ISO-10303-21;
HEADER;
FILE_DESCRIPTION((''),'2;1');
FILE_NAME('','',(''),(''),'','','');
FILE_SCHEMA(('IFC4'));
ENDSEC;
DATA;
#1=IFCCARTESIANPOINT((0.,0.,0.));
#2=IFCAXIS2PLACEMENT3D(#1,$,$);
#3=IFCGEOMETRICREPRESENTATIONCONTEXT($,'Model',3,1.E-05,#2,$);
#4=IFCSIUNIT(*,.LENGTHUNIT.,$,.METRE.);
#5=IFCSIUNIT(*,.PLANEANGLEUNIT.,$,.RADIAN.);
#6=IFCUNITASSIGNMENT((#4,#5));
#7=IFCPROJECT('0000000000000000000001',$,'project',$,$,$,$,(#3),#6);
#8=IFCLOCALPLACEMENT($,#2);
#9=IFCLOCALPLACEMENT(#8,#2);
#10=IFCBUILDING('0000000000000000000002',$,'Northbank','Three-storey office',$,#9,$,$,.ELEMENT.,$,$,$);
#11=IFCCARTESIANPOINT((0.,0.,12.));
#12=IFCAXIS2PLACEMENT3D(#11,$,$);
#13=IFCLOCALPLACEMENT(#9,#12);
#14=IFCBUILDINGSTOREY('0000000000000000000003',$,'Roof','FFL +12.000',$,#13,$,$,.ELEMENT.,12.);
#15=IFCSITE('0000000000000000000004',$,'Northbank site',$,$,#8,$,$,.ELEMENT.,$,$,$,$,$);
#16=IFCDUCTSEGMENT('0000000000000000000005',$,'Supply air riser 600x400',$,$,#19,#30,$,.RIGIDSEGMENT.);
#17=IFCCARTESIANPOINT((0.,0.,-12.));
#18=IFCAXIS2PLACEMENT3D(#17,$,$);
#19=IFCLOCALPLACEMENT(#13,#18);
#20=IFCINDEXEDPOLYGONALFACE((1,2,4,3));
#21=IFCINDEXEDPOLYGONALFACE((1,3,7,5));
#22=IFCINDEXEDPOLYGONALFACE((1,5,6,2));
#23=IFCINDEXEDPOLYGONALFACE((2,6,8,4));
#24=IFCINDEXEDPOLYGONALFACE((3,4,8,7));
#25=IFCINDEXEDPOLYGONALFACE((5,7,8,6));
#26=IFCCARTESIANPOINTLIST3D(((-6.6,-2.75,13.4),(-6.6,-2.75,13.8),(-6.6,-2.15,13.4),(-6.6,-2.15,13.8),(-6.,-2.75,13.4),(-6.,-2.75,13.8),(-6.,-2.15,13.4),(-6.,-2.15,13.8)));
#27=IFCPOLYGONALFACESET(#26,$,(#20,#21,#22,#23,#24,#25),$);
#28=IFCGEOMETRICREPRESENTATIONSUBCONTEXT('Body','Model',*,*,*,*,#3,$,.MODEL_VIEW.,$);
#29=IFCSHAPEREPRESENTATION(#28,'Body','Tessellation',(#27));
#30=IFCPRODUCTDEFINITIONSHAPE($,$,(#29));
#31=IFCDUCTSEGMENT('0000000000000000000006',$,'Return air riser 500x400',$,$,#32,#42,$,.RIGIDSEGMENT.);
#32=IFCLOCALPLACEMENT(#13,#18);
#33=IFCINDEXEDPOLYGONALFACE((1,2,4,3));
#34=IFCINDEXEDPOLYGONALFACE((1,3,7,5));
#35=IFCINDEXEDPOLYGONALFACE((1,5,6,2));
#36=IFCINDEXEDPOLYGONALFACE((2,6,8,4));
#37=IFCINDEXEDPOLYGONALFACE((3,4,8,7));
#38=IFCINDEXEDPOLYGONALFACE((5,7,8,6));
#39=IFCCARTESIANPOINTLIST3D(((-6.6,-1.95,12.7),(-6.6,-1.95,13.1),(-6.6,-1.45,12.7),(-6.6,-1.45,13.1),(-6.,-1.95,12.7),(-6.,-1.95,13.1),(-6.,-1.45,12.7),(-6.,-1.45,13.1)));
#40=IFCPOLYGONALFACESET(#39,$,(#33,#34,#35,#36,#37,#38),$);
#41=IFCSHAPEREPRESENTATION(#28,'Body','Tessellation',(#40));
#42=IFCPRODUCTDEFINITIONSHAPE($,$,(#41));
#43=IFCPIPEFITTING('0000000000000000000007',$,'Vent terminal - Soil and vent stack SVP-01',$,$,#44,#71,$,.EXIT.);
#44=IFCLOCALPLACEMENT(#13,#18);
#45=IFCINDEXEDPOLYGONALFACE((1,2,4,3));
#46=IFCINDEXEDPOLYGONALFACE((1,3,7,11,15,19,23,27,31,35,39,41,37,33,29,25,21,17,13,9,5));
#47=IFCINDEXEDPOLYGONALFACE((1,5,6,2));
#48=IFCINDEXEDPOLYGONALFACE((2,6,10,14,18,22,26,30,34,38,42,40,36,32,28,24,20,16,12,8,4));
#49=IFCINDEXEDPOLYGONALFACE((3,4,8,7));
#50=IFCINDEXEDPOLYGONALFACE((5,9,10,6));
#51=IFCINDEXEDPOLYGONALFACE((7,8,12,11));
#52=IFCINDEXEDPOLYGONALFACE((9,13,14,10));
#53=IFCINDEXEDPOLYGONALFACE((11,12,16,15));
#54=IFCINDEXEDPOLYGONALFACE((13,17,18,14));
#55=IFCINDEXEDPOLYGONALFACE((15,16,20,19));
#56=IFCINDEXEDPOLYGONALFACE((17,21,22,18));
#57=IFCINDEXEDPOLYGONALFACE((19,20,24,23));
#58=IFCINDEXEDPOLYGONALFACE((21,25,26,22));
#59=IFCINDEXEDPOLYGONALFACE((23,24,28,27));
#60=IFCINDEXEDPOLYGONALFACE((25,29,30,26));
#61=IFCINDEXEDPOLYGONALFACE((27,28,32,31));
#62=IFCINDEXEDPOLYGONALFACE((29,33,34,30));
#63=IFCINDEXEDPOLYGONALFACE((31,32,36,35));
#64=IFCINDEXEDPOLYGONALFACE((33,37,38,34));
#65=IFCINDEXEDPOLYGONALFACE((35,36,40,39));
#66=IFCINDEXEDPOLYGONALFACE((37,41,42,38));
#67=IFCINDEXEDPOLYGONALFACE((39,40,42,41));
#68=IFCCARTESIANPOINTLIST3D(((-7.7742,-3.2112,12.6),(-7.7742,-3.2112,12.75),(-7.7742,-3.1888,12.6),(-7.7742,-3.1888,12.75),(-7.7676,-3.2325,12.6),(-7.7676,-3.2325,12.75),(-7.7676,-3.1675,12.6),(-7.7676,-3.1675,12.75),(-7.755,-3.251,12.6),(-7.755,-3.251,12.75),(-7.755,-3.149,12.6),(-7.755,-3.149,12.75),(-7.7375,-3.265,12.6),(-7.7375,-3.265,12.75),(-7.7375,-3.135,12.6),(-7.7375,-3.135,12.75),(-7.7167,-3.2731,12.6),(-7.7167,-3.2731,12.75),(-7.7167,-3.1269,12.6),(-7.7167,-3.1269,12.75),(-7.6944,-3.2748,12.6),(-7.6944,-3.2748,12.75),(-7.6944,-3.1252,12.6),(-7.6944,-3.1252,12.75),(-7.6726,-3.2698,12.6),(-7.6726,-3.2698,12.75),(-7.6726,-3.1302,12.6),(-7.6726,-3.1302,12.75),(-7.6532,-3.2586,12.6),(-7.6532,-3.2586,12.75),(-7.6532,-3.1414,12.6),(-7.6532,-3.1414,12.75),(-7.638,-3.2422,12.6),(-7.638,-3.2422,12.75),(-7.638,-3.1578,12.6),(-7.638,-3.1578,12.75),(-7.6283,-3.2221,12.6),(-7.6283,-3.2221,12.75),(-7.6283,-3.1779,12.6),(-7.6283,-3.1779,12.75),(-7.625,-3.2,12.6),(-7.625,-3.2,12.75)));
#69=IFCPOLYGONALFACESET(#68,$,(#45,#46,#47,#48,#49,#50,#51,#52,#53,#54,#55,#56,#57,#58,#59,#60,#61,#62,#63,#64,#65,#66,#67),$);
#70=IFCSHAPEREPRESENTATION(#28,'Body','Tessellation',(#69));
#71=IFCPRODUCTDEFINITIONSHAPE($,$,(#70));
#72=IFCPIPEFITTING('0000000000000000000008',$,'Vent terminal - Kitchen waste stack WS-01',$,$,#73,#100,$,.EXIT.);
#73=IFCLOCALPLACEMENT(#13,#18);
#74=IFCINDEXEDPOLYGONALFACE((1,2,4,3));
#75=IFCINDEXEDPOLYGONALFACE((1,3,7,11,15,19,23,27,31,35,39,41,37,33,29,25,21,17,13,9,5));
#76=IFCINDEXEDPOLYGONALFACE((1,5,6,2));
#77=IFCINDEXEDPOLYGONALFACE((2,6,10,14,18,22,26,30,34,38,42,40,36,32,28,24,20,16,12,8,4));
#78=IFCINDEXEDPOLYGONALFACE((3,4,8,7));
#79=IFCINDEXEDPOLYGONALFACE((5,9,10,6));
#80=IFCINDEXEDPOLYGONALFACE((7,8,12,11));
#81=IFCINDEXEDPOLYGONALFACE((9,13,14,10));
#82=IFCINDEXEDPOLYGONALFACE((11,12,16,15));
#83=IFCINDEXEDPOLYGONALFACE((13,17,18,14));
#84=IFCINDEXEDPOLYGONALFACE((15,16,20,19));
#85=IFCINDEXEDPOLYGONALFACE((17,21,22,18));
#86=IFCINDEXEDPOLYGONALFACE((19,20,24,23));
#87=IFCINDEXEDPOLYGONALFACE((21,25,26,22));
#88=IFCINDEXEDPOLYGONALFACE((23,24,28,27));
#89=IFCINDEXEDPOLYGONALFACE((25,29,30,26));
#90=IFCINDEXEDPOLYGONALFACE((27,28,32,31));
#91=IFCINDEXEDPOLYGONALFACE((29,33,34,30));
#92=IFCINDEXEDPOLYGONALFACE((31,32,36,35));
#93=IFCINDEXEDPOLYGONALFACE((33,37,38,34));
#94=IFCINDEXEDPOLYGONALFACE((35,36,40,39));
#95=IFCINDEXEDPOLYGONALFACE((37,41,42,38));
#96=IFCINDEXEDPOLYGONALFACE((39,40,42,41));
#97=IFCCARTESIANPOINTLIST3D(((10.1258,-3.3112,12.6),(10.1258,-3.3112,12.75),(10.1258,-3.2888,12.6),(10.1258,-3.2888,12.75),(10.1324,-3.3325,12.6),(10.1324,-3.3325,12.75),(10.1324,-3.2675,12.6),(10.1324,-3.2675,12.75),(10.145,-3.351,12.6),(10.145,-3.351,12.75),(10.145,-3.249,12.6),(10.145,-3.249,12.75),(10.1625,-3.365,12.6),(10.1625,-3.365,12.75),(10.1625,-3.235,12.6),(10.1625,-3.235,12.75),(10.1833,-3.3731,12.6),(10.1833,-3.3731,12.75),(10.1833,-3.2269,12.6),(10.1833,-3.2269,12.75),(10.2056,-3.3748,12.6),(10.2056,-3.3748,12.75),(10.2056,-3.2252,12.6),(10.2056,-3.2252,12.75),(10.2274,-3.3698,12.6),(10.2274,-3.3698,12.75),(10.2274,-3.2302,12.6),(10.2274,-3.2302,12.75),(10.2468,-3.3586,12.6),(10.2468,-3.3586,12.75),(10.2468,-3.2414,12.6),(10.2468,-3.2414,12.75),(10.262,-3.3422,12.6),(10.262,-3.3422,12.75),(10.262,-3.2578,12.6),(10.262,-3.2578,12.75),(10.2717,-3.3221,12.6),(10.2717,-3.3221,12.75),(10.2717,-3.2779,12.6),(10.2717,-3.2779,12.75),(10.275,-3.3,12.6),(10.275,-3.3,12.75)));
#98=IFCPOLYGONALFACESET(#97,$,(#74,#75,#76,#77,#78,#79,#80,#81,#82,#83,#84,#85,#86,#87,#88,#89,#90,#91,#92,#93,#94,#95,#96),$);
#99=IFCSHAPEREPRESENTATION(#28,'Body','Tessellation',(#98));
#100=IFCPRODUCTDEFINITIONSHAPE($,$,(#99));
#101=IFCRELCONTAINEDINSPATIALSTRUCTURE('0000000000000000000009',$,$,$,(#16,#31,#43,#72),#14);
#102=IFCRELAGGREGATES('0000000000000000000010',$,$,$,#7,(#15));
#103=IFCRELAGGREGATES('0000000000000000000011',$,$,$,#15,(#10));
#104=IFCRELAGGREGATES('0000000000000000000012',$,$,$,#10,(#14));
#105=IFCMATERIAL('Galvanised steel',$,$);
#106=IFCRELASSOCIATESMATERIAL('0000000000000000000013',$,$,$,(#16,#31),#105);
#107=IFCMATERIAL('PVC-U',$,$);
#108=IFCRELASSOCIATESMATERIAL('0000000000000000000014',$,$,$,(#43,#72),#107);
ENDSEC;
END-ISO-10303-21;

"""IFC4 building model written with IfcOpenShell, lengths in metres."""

from ifc_helpers import new_model, si_unit, frame, origin, place, context, subcontext, project, spatial, rectangle, circle, extrude, material, element, save


model = new_model("IFC4")

# Units and contexts
model_context = context("Model", 3, precision=1e-05, world=origin())
body_context = subcontext(model_context, "Body", "Model", "MODEL_VIEW")
ifc_project = project(units=[si_unit("LENGTHUNIT", "METRE"), si_unit("PLANEANGLEUNIT", "RADIAN")], contexts=[model_context])

# Site, building, storey
site_placement = place(None, origin())
site = spatial("IfcSite", under=ifc_project, at=site_placement, Name="Northbank site", CompositionType="ELEMENT")
building_placement = place(site_placement, origin())
building = spatial("IfcBuilding", under=site, at=building_placement, Name="Northbank", Description="Three-storey office", CompositionType="ELEMENT")
storey_placement = place(building_placement, frame((0.0, 0.0, 12.0)))
storey = spatial("IfcBuildingStorey", under=building, at=storey_placement, Name="Roof", Description="FFL +12.000", CompositionType="ELEMENT", Elevation=12.0)

# Shared definitions
ifc_material_1 = material(Name="Galvanised steel")

# Duct segments
duct_segment_1_placement = place(storey_placement, frame((0.0, 0.0, -12.0)))
element("IfcDuctSegment", 1, at=duct_segment_1_placement, inside=storey, material=ifc_material_1, Name="Supply air riser 600x400", PredefinedType="RIGIDSEGMENT", context=body_context, shape_type="SweptSolid", body=[
    extrude(rectangle(XDim=0.6, YDim=0.4), frame((-6.0, -2.45, 13.6), z_axis=(-1.0, 0.0, 0.0), x_axis=(0.0, -1.0, 0.0)), (0.0, 0.0, 1.0), 0.6),
])
duct_segment_2_placement = place(storey_placement, frame((0.0, 0.0, -12.0)))
element("IfcDuctSegment", 2, at=duct_segment_2_placement, inside=storey, material=ifc_material_1, Name="Return air riser 500x400", PredefinedType="RIGIDSEGMENT", context=body_context, shape_type="SweptSolid", body=[
    extrude(rectangle(XDim=0.5, YDim=0.4), frame((-6.0, -1.7, 12.9), z_axis=(-1.0, 0.0, 0.0), x_axis=(0.0, -1.0, 0.0)), (0.0, 0.0, 1.0), 0.6),
])

# Pipe fittings
ifc_material_2 = material(Name="PVC-U")
pipe_fitting_1_placement = place(storey_placement, frame((0.0, 0.0, -12.0)))
element("IfcPipeFitting", 3, at=pipe_fitting_1_placement, inside=storey, material=ifc_material_2, Name="Vent terminal - Soil and vent stack SVP-01", PredefinedType="EXIT", context=body_context, shape_type="SweptSolid", body=[
    extrude(circle(Radius=0.075), frame((-7.7, -3.2, 12.6), z_axis=(0.0, 0.0, 1.0), x_axis=(1.0, 0.0, 0.0)), (0.0, 0.0, 1.0), 0.15),
])
pipe_fitting_2_placement = place(storey_placement, frame((0.0, 0.0, -12.0)))
element("IfcPipeFitting", 4, at=pipe_fitting_2_placement, inside=storey, material=ifc_material_2, Name="Vent terminal - Kitchen waste stack WS-01", PredefinedType="EXIT", context=body_context, shape_type="SweptSolid", body=[
    extrude(circle(Radius=0.075), frame((10.2, -3.3, 12.6), z_axis=(0.0, 0.0, 1.0), x_axis=(1.0, 0.0, 0.0)), (0.0, 0.0, 1.0), 0.15),
])

save(model, "model.ifc")
